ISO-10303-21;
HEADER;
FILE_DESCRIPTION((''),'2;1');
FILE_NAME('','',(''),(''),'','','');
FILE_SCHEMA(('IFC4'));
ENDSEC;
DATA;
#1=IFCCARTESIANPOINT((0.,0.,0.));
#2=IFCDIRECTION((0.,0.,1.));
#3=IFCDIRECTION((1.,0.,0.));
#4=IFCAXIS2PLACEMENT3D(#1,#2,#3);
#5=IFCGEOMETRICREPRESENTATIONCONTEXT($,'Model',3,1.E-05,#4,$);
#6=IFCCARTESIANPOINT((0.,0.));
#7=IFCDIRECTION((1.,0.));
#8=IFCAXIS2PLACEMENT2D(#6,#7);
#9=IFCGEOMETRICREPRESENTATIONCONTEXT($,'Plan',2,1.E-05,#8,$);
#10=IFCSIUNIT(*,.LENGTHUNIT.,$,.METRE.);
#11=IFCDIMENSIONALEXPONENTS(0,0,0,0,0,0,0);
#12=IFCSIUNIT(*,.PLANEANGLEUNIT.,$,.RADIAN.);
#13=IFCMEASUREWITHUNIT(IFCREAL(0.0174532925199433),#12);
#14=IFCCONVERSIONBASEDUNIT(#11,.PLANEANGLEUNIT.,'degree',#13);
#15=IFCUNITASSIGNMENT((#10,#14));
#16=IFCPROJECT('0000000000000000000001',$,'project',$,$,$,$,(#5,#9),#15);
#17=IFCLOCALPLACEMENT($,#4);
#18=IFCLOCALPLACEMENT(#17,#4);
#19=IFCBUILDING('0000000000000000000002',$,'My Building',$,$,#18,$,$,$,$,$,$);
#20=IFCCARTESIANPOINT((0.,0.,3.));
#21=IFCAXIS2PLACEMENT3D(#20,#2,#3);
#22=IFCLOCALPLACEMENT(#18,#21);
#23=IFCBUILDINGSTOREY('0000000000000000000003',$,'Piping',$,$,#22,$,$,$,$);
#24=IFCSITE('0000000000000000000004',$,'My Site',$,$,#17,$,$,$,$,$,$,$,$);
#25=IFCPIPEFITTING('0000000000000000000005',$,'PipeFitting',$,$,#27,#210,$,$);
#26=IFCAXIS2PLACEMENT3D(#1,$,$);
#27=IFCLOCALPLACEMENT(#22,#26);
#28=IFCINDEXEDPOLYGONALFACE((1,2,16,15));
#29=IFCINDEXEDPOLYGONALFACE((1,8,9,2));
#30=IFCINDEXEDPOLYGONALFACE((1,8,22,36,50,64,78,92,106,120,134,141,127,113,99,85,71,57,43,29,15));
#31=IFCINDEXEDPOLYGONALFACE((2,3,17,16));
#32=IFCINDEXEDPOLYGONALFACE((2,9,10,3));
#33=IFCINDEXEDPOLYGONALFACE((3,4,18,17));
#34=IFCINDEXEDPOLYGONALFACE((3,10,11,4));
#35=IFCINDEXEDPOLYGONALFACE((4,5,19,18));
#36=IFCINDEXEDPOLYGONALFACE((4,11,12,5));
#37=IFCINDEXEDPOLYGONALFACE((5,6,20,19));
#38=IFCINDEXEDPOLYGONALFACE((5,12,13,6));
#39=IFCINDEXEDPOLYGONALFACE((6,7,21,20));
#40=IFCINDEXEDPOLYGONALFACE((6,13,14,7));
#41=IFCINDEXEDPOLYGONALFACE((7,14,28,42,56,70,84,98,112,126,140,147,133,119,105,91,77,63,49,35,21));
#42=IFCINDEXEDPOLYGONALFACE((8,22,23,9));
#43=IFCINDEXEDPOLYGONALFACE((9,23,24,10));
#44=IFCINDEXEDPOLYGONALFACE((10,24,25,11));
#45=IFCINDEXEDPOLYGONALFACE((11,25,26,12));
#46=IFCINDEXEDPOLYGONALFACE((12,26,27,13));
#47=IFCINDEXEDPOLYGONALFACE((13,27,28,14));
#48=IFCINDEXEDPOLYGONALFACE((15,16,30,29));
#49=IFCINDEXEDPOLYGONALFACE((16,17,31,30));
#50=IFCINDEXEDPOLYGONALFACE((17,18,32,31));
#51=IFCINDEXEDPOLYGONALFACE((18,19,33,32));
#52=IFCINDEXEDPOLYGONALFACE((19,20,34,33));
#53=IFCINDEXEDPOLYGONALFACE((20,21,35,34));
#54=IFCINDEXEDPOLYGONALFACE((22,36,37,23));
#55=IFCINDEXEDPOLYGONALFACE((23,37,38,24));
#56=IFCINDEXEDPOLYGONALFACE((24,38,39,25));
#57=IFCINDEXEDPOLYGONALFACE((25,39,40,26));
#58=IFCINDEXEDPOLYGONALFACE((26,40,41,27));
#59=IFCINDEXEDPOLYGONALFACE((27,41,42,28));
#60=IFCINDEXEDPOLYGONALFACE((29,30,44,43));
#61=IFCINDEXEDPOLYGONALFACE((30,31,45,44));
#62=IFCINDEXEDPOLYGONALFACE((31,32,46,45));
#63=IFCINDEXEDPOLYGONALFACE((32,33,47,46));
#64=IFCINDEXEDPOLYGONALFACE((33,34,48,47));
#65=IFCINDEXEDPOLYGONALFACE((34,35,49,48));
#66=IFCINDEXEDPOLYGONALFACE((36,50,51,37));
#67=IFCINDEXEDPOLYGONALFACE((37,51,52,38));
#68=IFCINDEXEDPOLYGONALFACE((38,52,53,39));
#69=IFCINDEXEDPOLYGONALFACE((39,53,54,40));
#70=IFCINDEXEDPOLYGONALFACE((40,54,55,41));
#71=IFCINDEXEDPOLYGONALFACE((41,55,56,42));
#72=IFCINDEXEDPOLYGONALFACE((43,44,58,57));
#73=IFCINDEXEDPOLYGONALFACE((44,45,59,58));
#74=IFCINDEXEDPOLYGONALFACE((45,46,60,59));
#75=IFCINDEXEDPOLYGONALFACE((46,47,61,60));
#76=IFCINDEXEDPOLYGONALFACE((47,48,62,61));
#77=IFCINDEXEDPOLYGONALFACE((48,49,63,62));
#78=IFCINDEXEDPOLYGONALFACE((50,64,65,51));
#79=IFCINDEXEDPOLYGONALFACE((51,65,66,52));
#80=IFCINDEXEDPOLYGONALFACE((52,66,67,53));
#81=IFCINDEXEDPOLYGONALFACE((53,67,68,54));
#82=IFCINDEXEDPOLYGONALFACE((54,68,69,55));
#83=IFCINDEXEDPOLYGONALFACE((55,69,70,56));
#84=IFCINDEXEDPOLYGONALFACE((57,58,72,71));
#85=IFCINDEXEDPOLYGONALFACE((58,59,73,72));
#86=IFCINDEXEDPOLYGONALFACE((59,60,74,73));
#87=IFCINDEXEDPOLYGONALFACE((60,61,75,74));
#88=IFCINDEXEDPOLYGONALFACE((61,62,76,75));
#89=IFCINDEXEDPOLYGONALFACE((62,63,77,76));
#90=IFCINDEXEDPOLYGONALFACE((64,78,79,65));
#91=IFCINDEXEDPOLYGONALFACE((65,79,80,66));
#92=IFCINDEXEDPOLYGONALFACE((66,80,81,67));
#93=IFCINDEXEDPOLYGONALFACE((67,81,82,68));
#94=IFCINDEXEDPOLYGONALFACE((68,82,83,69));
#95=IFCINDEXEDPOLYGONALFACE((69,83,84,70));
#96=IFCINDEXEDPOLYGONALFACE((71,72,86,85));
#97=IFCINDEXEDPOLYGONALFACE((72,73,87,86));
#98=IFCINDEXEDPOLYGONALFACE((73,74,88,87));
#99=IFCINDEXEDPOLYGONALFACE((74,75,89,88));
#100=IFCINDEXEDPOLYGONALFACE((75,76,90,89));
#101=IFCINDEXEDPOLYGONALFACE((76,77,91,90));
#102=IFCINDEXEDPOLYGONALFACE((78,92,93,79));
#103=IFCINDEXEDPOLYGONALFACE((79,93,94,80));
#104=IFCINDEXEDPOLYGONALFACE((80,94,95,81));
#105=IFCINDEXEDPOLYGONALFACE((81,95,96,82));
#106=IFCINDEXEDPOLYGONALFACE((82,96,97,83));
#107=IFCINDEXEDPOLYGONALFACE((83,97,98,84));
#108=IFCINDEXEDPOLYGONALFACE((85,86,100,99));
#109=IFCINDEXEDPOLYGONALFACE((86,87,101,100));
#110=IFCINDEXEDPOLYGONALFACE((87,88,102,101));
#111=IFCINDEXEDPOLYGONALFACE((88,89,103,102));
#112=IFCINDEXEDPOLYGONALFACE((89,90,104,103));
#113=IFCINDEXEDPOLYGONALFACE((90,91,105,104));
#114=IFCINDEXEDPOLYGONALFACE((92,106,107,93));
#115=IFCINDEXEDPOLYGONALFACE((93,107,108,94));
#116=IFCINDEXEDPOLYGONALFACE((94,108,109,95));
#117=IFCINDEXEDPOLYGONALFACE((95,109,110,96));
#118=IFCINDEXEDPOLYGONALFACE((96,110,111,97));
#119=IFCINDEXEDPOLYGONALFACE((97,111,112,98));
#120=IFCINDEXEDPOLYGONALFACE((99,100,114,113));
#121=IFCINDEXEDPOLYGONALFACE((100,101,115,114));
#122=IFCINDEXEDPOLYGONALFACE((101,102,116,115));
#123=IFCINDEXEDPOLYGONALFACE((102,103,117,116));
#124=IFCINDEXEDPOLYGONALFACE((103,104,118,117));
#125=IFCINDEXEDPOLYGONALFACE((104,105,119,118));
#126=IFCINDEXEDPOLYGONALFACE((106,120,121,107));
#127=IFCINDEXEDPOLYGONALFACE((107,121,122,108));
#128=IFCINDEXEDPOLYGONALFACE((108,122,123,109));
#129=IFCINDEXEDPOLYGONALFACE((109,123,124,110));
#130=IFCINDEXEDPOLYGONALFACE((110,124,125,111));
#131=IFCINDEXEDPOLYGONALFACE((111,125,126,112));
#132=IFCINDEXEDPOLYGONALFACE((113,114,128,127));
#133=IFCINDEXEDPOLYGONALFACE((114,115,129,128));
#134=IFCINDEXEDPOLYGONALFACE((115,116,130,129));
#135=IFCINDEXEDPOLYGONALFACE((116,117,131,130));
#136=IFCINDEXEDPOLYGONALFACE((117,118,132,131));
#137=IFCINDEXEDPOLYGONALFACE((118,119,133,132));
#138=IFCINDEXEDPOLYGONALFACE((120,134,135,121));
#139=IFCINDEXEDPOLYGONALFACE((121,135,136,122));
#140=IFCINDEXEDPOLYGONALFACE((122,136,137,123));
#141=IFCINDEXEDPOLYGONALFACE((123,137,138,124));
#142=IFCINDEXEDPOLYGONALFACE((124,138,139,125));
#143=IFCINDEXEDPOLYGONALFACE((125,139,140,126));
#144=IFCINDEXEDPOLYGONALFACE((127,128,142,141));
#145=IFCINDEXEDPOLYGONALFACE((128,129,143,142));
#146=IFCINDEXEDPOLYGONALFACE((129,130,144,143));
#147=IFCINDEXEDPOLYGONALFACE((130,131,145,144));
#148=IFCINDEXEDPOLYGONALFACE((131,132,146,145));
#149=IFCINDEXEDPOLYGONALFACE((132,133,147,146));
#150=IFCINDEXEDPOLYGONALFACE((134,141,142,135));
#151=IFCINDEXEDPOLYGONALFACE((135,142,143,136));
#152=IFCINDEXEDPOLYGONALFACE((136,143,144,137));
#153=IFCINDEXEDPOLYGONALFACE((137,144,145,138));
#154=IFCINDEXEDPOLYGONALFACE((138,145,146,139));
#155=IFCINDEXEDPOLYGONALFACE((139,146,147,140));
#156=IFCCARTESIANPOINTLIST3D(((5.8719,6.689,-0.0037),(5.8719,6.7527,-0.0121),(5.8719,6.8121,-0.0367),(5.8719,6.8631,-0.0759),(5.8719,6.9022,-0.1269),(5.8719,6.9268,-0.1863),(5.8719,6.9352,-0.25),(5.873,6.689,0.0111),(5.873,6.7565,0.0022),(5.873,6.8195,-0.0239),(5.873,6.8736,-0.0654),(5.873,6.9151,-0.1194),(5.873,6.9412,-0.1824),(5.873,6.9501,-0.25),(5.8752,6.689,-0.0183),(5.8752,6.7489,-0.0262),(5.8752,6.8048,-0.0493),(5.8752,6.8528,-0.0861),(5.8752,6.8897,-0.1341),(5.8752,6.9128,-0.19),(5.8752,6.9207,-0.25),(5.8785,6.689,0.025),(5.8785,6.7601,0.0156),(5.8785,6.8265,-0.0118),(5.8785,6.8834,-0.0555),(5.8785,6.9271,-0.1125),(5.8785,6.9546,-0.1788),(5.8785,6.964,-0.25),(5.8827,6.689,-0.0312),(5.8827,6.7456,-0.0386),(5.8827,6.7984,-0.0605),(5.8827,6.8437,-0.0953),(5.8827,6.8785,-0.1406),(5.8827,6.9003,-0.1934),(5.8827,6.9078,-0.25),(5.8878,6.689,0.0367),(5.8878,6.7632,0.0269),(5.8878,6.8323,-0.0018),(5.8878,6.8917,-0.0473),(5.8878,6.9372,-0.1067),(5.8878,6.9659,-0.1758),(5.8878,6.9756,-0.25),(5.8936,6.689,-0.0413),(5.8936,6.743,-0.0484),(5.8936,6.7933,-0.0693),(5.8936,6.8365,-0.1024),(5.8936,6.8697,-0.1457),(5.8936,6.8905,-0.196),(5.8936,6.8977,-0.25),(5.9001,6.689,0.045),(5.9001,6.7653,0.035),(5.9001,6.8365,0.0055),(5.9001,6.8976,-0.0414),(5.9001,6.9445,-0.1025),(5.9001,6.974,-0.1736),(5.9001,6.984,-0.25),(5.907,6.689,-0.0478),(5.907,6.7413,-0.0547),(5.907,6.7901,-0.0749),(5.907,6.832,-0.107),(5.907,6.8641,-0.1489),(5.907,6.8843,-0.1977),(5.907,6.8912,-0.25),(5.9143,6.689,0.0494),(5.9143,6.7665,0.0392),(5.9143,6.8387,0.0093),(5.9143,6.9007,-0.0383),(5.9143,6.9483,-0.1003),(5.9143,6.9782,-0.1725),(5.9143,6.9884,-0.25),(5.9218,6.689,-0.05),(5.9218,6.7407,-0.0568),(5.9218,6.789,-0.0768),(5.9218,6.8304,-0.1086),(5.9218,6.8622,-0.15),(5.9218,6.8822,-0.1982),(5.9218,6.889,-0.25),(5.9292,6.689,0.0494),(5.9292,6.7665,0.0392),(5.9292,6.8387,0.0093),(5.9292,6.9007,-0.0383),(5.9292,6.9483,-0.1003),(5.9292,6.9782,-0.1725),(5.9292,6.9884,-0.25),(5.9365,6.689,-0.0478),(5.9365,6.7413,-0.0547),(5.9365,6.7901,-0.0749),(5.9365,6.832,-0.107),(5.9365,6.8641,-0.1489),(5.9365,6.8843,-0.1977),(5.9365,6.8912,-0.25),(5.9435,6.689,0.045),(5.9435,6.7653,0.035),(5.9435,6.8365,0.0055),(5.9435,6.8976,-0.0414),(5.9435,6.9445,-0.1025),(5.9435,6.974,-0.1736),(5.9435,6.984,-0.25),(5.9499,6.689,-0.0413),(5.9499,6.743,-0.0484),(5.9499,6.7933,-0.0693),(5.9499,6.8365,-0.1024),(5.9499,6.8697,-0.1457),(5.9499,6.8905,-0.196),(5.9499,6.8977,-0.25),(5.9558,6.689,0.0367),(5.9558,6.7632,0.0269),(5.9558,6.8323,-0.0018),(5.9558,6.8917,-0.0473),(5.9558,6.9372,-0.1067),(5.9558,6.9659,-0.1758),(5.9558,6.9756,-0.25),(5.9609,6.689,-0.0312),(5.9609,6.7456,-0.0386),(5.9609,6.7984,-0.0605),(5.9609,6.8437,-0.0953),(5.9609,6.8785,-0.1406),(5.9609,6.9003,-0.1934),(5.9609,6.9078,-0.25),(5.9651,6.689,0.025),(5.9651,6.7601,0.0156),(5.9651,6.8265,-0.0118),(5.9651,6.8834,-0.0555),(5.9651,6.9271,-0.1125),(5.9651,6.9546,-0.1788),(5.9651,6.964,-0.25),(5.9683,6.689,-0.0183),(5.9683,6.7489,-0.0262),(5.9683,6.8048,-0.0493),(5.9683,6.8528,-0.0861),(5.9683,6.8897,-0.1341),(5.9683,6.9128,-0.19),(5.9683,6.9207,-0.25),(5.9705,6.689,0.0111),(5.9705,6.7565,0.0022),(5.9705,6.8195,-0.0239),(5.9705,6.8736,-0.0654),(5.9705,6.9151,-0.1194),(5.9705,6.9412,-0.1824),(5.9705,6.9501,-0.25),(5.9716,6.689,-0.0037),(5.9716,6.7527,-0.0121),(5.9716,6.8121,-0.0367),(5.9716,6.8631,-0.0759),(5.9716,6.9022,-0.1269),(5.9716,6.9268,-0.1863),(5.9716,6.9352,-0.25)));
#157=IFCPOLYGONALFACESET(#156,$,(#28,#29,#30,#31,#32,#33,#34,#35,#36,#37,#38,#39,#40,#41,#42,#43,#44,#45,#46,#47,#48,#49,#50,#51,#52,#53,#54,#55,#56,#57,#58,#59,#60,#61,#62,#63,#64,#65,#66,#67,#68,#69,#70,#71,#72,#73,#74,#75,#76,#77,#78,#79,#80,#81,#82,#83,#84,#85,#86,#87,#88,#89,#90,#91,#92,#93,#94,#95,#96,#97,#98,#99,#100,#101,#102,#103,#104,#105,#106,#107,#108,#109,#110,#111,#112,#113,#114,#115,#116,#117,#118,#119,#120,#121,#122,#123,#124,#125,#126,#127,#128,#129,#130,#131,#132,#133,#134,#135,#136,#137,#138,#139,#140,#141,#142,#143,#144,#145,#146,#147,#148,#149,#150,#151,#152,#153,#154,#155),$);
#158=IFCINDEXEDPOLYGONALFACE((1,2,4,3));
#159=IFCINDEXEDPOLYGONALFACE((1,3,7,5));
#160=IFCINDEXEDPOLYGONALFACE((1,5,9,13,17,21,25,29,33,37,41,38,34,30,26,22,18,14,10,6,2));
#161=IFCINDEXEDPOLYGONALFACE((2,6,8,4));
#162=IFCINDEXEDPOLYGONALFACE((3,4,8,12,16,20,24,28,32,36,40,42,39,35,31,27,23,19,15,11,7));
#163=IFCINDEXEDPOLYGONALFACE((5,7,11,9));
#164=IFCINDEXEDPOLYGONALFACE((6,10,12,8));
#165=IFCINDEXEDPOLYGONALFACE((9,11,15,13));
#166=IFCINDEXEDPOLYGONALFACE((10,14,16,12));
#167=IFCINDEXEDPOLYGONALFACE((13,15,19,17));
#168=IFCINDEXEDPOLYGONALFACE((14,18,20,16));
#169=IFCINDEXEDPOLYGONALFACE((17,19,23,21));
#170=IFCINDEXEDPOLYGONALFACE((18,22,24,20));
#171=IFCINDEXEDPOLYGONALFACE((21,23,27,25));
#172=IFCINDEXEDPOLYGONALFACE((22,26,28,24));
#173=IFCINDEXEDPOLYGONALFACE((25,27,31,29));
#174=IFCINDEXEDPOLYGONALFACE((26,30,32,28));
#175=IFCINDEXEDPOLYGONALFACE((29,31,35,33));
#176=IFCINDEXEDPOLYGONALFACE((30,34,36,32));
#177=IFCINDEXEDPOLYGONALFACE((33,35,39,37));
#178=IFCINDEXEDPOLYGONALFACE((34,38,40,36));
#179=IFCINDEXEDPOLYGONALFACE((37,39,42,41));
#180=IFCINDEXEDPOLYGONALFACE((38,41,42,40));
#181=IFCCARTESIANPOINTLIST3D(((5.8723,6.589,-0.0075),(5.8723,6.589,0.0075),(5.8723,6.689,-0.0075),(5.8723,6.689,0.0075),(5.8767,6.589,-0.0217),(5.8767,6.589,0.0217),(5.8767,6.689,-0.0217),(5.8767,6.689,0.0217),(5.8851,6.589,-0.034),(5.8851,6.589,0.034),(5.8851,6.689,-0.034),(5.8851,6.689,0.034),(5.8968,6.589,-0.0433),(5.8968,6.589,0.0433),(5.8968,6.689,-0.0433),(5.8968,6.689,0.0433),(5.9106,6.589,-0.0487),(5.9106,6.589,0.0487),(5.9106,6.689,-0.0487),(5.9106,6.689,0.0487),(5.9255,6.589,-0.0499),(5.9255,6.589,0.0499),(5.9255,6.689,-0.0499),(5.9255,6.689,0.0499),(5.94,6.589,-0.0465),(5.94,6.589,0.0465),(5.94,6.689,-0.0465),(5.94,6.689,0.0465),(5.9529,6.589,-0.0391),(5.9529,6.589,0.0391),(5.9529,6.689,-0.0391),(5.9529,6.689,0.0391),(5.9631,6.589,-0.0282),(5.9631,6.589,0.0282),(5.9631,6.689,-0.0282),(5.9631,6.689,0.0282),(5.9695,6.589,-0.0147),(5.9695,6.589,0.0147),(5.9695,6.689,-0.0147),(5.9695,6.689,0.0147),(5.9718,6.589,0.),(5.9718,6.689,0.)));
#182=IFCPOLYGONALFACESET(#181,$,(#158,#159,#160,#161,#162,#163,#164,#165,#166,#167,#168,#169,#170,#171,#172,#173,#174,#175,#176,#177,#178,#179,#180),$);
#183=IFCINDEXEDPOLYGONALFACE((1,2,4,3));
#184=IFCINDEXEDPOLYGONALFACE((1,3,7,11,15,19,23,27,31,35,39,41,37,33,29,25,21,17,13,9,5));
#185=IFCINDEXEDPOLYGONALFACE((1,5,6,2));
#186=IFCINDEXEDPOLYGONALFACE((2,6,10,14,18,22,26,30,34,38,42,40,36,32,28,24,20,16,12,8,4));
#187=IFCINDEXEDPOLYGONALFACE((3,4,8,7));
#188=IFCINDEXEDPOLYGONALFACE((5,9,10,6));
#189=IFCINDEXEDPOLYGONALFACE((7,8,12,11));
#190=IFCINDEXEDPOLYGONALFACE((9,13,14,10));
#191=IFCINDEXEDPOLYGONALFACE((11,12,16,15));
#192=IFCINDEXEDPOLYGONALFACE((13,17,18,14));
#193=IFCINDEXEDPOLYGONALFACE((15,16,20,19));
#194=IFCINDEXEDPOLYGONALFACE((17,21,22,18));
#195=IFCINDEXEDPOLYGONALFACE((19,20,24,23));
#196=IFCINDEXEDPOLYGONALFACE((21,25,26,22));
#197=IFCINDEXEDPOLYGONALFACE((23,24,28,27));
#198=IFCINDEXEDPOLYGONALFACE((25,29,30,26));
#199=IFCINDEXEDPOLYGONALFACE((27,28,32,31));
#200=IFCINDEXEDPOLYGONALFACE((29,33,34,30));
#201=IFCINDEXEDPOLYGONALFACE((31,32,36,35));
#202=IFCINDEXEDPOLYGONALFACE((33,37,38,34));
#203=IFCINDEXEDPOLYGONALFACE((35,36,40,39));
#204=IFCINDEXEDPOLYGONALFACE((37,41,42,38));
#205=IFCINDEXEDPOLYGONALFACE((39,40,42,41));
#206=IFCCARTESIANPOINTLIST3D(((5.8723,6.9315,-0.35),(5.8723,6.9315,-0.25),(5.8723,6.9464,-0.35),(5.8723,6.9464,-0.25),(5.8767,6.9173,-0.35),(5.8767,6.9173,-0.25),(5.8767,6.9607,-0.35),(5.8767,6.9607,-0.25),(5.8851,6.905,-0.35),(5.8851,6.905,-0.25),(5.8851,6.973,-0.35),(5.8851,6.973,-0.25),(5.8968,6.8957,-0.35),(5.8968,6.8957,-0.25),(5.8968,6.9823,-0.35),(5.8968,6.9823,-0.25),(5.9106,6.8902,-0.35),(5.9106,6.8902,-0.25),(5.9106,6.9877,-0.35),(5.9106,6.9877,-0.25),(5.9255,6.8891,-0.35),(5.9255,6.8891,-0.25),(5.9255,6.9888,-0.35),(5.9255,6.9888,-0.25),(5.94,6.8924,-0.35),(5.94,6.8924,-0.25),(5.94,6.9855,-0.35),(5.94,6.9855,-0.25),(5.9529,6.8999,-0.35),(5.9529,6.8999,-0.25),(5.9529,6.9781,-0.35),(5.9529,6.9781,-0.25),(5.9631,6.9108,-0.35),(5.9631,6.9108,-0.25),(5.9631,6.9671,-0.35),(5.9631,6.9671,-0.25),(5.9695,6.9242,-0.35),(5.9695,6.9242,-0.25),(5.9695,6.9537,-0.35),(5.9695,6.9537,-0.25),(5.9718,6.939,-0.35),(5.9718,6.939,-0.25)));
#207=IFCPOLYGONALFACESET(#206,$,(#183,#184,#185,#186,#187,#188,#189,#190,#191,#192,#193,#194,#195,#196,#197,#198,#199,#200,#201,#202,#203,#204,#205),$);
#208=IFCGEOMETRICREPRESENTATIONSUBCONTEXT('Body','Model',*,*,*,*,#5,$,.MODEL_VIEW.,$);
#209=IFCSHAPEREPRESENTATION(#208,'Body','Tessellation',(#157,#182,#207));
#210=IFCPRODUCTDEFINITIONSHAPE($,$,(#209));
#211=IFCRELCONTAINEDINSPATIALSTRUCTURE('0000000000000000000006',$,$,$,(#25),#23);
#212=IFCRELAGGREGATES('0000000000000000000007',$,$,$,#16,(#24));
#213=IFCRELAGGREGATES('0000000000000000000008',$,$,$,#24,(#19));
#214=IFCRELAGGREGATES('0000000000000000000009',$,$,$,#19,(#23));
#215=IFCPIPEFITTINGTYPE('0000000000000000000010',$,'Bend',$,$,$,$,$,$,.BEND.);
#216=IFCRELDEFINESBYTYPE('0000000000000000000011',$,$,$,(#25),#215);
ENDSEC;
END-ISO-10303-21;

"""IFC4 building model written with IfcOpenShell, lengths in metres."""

from ifc_helpers import new_model, entity, si_unit, converted_unit, frame, origin_with_axes, origin_2d_with_axis, place, context, subcontext, project, spatial, circle, extrude, source, transform, mapped, type_object, type_shapes, element, save


model = new_model("IFC4")

# Units and contexts
model_context = context("Model", 3, precision=1e-05, world=origin_with_axes())
plan_context = context("Plan", 2, precision=1e-05, world=origin_2d_with_axis())
body_context = subcontext(model_context, "Body", "Model", "MODEL_VIEW")
ifc_project = project(units=[si_unit("LENGTHUNIT", "METRE"), converted_unit("PLANEANGLEUNIT", "degree", entity("IfcReal", 0.0174532925199433), si_unit("PLANEANGLEUNIT", "RADIAN"), dimensions=[0, 0, 0, 0, 0, 0, 0])], contexts=[model_context, plan_context])

# Site, building, storey
site_placement = place(None, origin_with_axes())
site = spatial("IfcSite", under=ifc_project, at=site_placement, Name="My Site")
building_placement = place(site_placement, origin_with_axes())
building = spatial("IfcBuilding", under=site, at=building_placement, Name="My Building")
storey_placement = place(building_placement, frame((0.0, 0.0, 3.0), z_axis=(0.0, 0.0, 1.0), x_axis=(1.0, 0.0, 0.0)))
storey = spatial("IfcBuildingStorey", under=building, at=storey_placement, Name="Piping")

# Pipe fitting
pipe_fitting_type_1 = type_object("IfcPipeFittingType", Name="Bend", PredefinedType="BEND")
shared_shape = source(origin_with_axes(), body_context, "Body", "SolidModel", [
    entity("IfcSweptDiskSolid", entity("IfcIndexedPolyCurve", entity("IfcCartesianPointList3D", [[0.0, 0.0, -0.1], [0.0, -0.0732, -0.2768], [0.0, -0.25, -0.35]]), [entity("IfcArcIndex", [1, 2, 3])]), 0.05),
    extrude(circle(Radius=0.05), origin_with_axes(), (0.0, 0.0, -1.0), 0.1),
    extrude(circle(Radius=0.05), frame((0.0, -0.25, -0.35), z_axis=(0.0, -1.0, 0.0), x_axis=(1.0, 0.0, 0.0)), (0.0, 0.0, 1.0), 0.1),
])
type_shapes(pipe_fitting_type_1, [shared_shape])
for number, where, z_axis, x_axis, name in (
    (1, (5.9218, 6.589, 0.0), (0.0, -1.0, 0.0), (1.0, 0.0, 0.0), "PipeFitting"),
):
    element("IfcPipeFitting", number, at=place(storey_placement, frame(where, z_axis=z_axis, x_axis=x_axis)), inside=storey, type_object=pipe_fitting_type_1, Name=name, context=body_context, shape_type="MappedRepresentation", body=[
        mapped(shared_shape, transform((0.0, 0.0, 0.0), x_axis=(1.0, 0.0, 0.0), y_axis=(0.0, 1.0, 0.0), z_axis=(0.0, 0.0, 1.0), scale=1.0)),
    ])

save(model, "model.ifc")
